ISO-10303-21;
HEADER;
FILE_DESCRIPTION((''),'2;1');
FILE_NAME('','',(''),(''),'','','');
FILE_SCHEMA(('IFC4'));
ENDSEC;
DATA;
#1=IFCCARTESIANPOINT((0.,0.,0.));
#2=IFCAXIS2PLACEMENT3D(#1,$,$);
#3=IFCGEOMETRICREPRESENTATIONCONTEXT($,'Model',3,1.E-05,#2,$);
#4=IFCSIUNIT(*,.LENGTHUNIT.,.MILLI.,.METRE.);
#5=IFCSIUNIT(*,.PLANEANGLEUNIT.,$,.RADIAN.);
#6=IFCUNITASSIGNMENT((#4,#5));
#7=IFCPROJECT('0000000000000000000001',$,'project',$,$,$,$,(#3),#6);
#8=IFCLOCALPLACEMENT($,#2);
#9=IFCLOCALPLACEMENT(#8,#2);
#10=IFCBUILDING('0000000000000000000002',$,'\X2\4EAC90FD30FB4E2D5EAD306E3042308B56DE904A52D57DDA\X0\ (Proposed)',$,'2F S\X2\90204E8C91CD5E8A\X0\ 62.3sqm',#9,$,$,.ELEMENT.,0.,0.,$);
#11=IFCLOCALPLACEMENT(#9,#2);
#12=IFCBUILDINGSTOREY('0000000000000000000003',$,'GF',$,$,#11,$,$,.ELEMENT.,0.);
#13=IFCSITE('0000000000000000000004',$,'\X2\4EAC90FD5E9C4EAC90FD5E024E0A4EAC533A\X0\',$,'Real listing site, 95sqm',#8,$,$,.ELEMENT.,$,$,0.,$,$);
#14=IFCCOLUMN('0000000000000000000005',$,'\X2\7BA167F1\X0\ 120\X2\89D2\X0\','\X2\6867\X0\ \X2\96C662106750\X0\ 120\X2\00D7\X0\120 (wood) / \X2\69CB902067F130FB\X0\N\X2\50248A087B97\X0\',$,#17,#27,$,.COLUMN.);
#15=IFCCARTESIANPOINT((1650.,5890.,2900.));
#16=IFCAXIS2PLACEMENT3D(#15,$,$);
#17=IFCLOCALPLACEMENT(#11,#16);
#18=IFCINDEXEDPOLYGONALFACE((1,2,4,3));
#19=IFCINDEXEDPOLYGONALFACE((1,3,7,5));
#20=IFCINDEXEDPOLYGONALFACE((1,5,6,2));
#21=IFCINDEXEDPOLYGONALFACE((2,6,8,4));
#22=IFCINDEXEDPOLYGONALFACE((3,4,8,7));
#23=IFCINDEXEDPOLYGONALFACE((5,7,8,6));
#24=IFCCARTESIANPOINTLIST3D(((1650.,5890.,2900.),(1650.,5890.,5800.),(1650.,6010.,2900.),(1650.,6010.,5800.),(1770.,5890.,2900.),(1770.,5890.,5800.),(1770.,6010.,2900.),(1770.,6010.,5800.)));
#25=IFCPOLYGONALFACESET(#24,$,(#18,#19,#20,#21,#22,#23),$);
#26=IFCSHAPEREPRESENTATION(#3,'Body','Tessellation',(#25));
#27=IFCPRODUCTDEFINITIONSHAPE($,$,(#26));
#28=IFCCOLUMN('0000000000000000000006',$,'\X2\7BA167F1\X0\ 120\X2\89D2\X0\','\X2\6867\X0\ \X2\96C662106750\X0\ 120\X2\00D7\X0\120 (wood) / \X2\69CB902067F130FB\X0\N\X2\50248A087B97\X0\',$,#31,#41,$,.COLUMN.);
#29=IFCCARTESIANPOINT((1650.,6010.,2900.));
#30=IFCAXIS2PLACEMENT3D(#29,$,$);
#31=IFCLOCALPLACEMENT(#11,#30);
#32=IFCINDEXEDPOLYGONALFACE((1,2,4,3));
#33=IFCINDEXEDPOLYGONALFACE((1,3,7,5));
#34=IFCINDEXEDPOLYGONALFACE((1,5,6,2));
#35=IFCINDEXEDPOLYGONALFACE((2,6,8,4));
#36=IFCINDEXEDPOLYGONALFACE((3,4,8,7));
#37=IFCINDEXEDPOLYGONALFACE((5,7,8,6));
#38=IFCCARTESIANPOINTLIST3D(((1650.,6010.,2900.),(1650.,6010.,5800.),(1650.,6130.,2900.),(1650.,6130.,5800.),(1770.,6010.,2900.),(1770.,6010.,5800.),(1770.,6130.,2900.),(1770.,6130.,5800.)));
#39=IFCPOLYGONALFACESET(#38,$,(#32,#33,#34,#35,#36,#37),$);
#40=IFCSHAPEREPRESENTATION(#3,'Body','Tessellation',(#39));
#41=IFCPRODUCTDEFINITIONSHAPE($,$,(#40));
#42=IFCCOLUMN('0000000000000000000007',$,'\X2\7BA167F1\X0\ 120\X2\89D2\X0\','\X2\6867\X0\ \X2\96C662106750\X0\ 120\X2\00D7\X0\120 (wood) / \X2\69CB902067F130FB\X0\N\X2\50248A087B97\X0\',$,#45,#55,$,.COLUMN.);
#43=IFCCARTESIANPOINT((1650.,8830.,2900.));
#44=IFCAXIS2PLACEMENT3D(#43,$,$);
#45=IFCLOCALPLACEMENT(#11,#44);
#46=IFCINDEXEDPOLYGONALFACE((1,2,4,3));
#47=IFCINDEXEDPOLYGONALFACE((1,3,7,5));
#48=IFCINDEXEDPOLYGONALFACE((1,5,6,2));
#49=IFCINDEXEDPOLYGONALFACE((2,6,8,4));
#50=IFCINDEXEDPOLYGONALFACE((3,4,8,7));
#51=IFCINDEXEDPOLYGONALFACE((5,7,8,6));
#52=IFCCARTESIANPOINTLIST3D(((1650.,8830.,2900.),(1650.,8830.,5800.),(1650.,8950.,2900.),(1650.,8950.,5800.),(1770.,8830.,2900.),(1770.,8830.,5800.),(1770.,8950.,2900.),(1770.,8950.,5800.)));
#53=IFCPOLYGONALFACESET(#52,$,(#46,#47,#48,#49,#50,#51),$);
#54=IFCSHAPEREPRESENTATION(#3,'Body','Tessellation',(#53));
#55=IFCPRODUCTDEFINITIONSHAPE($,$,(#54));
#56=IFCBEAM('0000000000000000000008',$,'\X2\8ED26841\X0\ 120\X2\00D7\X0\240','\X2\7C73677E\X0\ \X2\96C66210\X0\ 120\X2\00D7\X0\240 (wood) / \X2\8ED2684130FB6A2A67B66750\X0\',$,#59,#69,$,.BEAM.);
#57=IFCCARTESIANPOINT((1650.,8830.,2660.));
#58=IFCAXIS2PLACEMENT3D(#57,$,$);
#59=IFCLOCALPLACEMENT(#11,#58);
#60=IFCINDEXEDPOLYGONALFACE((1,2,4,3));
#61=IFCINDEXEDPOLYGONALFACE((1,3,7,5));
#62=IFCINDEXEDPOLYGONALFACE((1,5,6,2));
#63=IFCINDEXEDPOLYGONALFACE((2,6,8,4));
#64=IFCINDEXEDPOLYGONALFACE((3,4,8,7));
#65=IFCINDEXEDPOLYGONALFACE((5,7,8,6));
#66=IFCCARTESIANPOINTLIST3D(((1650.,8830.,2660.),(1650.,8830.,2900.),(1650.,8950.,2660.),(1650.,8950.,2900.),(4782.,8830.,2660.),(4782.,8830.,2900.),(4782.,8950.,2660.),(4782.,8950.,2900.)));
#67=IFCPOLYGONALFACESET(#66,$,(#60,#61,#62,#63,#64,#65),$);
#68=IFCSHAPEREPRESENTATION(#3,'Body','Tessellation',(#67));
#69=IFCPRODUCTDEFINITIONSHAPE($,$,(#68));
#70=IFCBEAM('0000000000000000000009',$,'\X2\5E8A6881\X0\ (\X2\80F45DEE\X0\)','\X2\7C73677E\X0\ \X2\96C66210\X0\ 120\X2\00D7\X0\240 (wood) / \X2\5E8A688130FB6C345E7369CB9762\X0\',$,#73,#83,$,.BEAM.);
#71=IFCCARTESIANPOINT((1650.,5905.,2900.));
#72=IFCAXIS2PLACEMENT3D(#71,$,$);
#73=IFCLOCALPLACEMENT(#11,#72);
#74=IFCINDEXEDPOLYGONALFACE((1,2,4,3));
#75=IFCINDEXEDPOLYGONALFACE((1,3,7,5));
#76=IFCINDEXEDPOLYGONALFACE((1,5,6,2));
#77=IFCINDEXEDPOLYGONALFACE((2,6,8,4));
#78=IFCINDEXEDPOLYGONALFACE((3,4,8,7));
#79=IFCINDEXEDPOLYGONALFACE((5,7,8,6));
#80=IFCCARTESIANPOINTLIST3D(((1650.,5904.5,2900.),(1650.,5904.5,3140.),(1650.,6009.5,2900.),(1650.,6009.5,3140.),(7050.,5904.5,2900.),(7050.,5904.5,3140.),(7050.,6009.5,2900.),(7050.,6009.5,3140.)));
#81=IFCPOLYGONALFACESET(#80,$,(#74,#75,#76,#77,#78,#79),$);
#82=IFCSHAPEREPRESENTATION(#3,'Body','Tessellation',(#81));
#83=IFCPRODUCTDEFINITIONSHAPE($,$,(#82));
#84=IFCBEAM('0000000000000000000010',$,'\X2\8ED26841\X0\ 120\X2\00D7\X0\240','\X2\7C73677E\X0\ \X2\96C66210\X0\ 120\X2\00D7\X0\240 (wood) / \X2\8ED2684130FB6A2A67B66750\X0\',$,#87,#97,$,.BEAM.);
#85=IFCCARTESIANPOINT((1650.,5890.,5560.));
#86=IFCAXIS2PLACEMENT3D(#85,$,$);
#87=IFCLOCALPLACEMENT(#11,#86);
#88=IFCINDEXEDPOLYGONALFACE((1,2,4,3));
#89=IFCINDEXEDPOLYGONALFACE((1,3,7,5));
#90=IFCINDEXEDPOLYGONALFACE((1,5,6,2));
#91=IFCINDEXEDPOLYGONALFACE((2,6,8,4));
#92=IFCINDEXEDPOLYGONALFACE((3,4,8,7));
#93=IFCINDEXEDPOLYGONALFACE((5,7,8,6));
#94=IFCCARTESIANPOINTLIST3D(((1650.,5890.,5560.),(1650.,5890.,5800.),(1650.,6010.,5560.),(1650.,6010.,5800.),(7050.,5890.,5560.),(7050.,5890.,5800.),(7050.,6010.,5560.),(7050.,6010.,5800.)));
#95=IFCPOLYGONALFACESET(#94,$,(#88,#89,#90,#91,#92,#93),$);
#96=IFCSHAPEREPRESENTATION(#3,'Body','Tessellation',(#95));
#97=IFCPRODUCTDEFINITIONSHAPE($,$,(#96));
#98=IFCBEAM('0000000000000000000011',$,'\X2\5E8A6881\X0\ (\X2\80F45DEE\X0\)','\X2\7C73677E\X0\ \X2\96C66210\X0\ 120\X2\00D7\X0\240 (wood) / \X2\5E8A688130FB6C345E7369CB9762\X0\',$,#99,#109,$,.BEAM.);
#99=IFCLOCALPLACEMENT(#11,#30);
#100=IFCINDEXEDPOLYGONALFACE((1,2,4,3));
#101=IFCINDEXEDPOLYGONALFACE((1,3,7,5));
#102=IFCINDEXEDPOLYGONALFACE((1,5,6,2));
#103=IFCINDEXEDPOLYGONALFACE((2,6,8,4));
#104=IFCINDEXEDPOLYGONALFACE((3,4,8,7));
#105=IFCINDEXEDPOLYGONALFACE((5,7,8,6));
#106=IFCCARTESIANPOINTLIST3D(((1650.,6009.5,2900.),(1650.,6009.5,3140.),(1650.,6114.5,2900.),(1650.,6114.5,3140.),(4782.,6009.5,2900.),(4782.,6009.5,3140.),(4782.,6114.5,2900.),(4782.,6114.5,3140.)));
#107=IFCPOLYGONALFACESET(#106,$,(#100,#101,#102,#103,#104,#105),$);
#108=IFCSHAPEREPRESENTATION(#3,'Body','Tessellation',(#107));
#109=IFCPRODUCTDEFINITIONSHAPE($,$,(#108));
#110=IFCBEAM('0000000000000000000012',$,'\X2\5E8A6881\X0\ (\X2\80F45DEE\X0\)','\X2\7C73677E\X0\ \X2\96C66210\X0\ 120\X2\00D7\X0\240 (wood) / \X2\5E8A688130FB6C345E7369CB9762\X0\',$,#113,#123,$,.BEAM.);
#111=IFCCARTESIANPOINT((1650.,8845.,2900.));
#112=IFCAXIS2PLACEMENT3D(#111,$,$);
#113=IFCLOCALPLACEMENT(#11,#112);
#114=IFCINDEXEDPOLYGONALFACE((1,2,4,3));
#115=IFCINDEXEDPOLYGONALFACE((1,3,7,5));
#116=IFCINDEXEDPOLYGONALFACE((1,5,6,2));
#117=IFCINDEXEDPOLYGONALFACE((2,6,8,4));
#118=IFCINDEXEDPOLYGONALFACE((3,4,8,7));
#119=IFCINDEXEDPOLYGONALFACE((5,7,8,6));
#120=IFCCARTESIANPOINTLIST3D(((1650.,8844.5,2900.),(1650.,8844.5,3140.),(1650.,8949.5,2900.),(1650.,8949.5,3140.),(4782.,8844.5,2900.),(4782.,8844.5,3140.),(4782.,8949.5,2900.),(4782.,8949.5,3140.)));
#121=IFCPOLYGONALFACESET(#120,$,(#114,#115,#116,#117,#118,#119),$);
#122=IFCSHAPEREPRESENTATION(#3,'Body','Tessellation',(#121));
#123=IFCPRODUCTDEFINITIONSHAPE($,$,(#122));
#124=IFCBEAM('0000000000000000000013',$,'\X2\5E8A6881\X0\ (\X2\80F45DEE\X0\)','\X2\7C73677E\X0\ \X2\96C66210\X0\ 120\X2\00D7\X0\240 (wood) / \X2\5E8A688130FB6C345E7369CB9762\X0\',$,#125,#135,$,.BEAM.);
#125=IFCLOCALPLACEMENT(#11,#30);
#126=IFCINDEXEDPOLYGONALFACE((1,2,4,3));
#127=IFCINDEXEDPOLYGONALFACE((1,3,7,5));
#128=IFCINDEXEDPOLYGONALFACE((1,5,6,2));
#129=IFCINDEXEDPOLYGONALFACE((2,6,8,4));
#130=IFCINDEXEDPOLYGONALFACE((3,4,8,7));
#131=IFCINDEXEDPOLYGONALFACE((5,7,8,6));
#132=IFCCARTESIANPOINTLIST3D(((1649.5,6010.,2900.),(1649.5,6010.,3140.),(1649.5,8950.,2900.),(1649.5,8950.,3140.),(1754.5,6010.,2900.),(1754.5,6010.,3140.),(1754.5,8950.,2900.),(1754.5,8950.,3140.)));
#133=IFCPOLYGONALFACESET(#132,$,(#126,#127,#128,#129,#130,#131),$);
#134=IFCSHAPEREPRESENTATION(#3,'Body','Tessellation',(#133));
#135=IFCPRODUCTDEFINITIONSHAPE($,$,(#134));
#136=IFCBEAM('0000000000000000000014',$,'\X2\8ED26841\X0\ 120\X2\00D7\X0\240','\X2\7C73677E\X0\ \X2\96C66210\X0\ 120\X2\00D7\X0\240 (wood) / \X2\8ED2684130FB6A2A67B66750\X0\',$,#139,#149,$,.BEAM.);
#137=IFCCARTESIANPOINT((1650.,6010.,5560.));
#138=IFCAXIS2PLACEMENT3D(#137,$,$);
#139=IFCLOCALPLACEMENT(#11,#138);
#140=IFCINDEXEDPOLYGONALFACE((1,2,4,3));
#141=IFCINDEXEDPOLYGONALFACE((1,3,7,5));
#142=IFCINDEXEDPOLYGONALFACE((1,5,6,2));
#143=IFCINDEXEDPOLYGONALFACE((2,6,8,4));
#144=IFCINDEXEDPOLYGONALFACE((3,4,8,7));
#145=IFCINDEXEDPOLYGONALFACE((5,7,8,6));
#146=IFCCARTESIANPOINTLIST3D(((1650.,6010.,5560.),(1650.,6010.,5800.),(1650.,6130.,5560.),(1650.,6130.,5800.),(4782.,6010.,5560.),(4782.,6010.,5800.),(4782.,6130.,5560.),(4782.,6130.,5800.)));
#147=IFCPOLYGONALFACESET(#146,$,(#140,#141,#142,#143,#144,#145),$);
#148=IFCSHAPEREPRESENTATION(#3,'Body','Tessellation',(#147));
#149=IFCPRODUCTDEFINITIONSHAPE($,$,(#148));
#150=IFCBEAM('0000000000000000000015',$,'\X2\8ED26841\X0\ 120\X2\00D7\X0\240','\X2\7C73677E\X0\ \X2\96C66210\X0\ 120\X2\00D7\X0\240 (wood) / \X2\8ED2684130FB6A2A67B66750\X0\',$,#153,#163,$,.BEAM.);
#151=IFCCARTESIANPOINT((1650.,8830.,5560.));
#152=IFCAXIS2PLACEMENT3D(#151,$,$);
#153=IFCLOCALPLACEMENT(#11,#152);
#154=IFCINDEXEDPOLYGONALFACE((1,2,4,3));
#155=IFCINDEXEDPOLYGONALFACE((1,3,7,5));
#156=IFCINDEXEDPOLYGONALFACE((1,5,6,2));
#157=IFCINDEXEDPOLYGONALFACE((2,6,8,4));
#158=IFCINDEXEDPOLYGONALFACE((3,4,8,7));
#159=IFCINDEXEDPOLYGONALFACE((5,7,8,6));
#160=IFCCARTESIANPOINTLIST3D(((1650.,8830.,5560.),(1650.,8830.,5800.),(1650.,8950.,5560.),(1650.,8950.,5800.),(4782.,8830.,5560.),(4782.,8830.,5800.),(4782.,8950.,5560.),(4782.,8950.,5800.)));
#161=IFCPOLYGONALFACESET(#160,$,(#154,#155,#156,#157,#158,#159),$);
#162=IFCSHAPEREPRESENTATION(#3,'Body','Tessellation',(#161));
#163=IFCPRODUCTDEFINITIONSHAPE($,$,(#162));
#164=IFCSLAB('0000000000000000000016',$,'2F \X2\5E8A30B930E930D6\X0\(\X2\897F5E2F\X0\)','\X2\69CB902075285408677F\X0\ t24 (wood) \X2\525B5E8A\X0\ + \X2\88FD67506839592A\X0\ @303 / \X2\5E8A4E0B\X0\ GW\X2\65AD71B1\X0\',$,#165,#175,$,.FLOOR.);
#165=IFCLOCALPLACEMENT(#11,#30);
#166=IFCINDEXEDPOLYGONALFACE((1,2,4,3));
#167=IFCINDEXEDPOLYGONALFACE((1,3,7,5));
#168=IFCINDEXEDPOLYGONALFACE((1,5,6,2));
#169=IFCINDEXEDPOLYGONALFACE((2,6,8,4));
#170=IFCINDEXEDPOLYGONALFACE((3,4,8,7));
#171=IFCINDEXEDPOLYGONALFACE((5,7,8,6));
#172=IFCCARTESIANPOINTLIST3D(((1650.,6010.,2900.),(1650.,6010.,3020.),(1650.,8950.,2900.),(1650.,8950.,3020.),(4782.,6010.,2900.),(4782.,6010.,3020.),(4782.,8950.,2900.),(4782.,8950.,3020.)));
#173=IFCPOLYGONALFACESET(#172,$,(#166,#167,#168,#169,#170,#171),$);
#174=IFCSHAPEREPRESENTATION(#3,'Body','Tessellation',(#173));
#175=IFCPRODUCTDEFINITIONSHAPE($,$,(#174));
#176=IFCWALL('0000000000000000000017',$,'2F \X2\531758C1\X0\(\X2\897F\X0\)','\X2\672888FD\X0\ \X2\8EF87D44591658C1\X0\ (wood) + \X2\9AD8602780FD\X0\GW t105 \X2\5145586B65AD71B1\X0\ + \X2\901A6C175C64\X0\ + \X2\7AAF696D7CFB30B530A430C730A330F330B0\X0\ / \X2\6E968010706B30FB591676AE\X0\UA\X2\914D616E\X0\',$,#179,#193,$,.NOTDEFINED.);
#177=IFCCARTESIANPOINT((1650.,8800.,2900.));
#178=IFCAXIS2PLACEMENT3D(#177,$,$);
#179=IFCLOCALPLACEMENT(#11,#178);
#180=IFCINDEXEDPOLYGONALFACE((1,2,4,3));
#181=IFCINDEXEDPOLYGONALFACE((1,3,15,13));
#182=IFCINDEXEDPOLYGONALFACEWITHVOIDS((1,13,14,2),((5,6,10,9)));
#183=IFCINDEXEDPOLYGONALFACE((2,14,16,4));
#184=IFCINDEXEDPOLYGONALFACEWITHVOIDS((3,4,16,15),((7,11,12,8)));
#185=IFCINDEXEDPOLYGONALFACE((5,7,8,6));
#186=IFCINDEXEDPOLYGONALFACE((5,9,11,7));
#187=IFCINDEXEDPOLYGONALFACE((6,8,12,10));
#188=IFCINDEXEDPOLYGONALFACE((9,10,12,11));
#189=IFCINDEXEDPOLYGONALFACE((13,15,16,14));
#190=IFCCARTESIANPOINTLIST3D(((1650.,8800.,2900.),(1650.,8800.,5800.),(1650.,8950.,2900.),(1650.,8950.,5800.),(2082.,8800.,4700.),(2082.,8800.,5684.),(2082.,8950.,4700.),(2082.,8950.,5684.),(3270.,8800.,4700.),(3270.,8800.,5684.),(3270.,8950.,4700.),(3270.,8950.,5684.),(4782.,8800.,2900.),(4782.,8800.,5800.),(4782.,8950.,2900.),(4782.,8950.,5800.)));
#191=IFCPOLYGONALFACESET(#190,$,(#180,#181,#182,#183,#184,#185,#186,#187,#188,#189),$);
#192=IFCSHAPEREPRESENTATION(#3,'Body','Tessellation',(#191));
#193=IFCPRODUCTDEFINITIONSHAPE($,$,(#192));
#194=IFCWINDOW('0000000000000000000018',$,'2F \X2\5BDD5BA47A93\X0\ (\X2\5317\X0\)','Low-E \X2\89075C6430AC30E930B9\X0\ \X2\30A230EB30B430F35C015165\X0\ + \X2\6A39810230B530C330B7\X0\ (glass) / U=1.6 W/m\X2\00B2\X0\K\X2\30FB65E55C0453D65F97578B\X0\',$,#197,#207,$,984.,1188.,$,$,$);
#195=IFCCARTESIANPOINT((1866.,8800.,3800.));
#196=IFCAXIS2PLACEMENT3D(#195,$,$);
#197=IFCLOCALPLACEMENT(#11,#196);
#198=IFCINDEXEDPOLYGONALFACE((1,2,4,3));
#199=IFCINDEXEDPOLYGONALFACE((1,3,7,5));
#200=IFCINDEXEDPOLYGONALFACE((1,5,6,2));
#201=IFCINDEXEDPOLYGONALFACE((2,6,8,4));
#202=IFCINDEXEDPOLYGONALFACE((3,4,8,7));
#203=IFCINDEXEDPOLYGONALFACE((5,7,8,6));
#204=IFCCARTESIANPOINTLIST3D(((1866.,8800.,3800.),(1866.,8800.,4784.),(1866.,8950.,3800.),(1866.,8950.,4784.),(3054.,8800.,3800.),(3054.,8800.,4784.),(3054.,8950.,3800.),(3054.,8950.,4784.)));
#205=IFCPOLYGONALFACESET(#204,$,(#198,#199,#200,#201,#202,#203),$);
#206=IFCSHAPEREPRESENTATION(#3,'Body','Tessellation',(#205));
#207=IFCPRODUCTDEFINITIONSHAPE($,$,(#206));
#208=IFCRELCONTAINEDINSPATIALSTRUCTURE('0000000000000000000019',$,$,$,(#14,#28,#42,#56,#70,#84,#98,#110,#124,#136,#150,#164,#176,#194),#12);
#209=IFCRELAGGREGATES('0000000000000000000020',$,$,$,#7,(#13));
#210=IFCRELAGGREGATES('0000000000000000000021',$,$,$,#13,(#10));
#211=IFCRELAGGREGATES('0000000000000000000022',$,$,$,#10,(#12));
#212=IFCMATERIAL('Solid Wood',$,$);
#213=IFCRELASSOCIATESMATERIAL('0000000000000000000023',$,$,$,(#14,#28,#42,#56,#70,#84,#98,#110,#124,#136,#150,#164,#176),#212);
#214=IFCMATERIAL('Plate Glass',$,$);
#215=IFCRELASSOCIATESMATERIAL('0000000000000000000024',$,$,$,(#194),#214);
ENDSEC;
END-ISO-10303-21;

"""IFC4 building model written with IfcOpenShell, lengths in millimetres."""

from ifc_helpers import new_model, si_unit, frame, frame_2d, origin, place, context, project, spatial, rectangle, extrude, material, element, fill, save


model = new_model("IFC4")

# Units and contexts
model_context = context("Model", 3, precision=1e-05, world=origin())
ifc_project = project(units=[si_unit("LENGTHUNIT", "METRE", prefix="MILLI"), si_unit("PLANEANGLEUNIT", "RADIAN")], contexts=[model_context])

# Site, building, storey
site_placement = place(None, origin())
site = spatial("IfcSite", under=ifc_project, at=site_placement, Name="京都府京都市上京区", ObjectType="Real listing site, 95sqm", CompositionType="ELEMENT", RefElevation=0.0)
building_placement = place(site_placement, origin())
building = spatial("IfcBuilding", under=site, at=building_placement, Name="京都・中庭のある回遊動線 (Proposed)", ObjectType="2F S造二重床 62.3sqm", CompositionType="ELEMENT", ElevationOfRefHeight=0.0, ElevationOfTerrain=0.0)
storey_placement = place(building_placement, origin())
storey = spatial("IfcBuildingStorey", under=building, at=storey_placement, Name="GF", CompositionType="ELEMENT", Elevation=0.0)

# Columns
ifc_material_1 = material(Name="Solid Wood")
column_1_placement = place(storey_placement, frame((1650.0, 5890.0, 2900.0)))
element("IfcColumn", 1, at=column_1_placement, inside=storey, material=ifc_material_1, Name="管柱 120角", Description="桧 集成材 120×120 (wood) / 構造柱・N値計算", PredefinedType="COLUMN", context=model_context, shape_type="SweptSolid", body=[
    extrude(rectangle(XDim=120.0, YDim=120.0, at=frame_2d((60.0, 60.0))), frame((1650.0, 5890.0, 2900.0)), (0.0, 0.0, 1.0), 2900.0),
])
column_2_placement = place(storey_placement, frame((1650.0, 6010.0, 2900.0)))
element("IfcColumn", 2, at=column_2_placement, inside=storey, material=ifc_material_1, Name="管柱 120角", Description="桧 集成材 120×120 (wood) / 構造柱・N値計算", PredefinedType="COLUMN", context=model_context, shape_type="SweptSolid", body=[
    extrude(rectangle(XDim=120.0, YDim=120.0, at=frame_2d((60.0, 60.0))), frame((1650.0, 6010.0, 2900.0)), (0.0, 0.0, 1.0), 2900.0),
])
column_3_placement = place(storey_placement, frame((1650.0, 8830.0, 2900.0)))
element("IfcColumn", 3, at=column_3_placement, inside=storey, material=ifc_material_1, Name="管柱 120角", Description="桧 集成材 120×120 (wood) / 構造柱・N値計算", PredefinedType="COLUMN", context=model_context, shape_type="SweptSolid", body=[
    extrude(rectangle(XDim=120.0, YDim=120.0, at=frame_2d((60.0, 60.0))), frame((1650.0, 8830.0, 2900.0)), (0.0, 0.0, 1.0), 2900.0),
])

# Beams
beam_1_placement = place(storey_placement, frame((1650.0, 8830.0, 2660.0)))
element("IfcBeam", 4, at=beam_1_placement, inside=storey, material=ifc_material_1, Name="軒桁 120×240", Description="米松 集成 120×240 (wood) / 軒桁・横架材", PredefinedType="BEAM", context=model_context, shape_type="SweptSolid", body=[
    extrude(rectangle(XDim=3132.0, YDim=120.0, at=frame_2d((1566.0, 60.0))), frame((1650.0, 8830.0, 2660.0)), (0.0, 0.0, 1.0), 240.0),
])
beam_2_placement = place(storey_placement, frame((1650.0, 5905.0, 2900.0)))
element("IfcBeam", 5, at=beam_2_placement, inside=storey, material=ifc_material_1, Name="床梁 (胴差)", Description="米松 集成 120×240 (wood) / 床梁・水平構面", PredefinedType="BEAM", context=model_context, shape_type="SweptSolid", body=[
    extrude(rectangle(XDim=5400.0, YDim=105.0, at=frame_2d((2700.0, 52.0))), frame((1650.0, 5905.0, 2900.0)), (0.0, 0.0, 1.0), 240.0),
])
beam_3_placement = place(storey_placement, frame((1650.0, 5890.0, 5560.0)))
element("IfcBeam", 6, at=beam_3_placement, inside=storey, material=ifc_material_1, Name="軒桁 120×240", Description="米松 集成 120×240 (wood) / 軒桁・横架材", PredefinedType="BEAM", context=model_context, shape_type="SweptSolid", body=[
    extrude(rectangle(XDim=5400.0, YDim=120.0, at=frame_2d((2700.0, 60.0))), frame((1650.0, 5890.0, 5560.0)), (0.0, 0.0, 1.0), 240.0),
])
beam_4_placement = place(storey_placement, frame((1650.0, 6010.0, 2900.0)))
element("IfcBeam", 7, at=beam_4_placement, inside=storey, material=ifc_material_1, Name="床梁 (胴差)", Description="米松 集成 120×240 (wood) / 床梁・水平構面", PredefinedType="BEAM", context=model_context, shape_type="SweptSolid", body=[
    extrude(rectangle(XDim=3132.0, YDim=105.0, at=frame_2d((1566.0, 52.0))), frame((1650.0, 6010.0, 2900.0)), (0.0, 0.0, 1.0), 240.0),
])
beam_5_placement = place(storey_placement, frame((1650.0, 8845.0, 2900.0)))
element("IfcBeam", 8, at=beam_5_placement, inside=storey, material=ifc_material_1, Name="床梁 (胴差)", Description="米松 集成 120×240 (wood) / 床梁・水平構面", PredefinedType="BEAM", context=model_context, shape_type="SweptSolid", body=[
    extrude(rectangle(XDim=3132.0, YDim=105.0, at=frame_2d((1566.0, 52.0))), frame((1650.0, 8845.0, 2900.0)), (0.0, 0.0, 1.0), 240.0),
])
beam_6_placement = place(storey_placement, frame((1650.0, 6010.0, 2900.0)))
element("IfcBeam", 9, at=beam_6_placement, inside=storey, material=ifc_material_1, Name="床梁 (胴差)", Description="米松 集成 120×240 (wood) / 床梁・水平構面", PredefinedType="BEAM", context=model_context, shape_type="SweptSolid", body=[
    extrude(rectangle(XDim=105.0, YDim=2940.0, at=frame_2d((52.0, 1470.0))), frame((1650.0, 6010.0, 2900.0)), (0.0, 0.0, 1.0), 240.0),
])
beam_7_placement = place(storey_placement, frame((1650.0, 6010.0, 5560.0)))
element("IfcBeam", 10, at=beam_7_placement, inside=storey, material=ifc_material_1, Name="軒桁 120×240", Description="米松 集成 120×240 (wood) / 軒桁・横架材", PredefinedType="BEAM", context=model_context, shape_type="SweptSolid", body=[
    extrude(rectangle(XDim=3132.0, YDim=120.0, at=frame_2d((1566.0, 60.0))), frame((1650.0, 6010.0, 5560.0)), (0.0, 0.0, 1.0), 240.0),
])
beam_8_placement = place(storey_placement, frame((1650.0, 8830.0, 5560.0)))
element("IfcBeam", 11, at=beam_8_placement, inside=storey, material=ifc_material_1, Name="軒桁 120×240", Description="米松 集成 120×240 (wood) / 軒桁・横架材", PredefinedType="BEAM", context=model_context, shape_type="SweptSolid", body=[
    extrude(rectangle(XDim=3132.0, YDim=120.0, at=frame_2d((1566.0, 60.0))), frame((1650.0, 8830.0, 5560.0)), (0.0, 0.0, 1.0), 240.0),
])

# Slab
slab_placement = place(storey_placement, frame((1650.0, 6010.0, 2900.0)))
element("IfcSlab", 12, at=slab_placement, inside=storey, material=ifc_material_1, Name="2F 床スラブ(西帯)", Description="構造用合板 t24 (wood) 剛床 + 製材根太 @303 / 床下 GW断熱", PredefinedType="FLOOR", context=model_context, shape_type="SweptSolid", body=[
    extrude(rectangle(XDim=3132.0, YDim=2940.0, at=frame_2d((1566.0, 1470.0))), frame((1650.0, 6010.0, 2900.0)), (0.0, 0.0, 1.0), 120.0),
])

# Wall, opening, window
wall_1_placement = place(storey_placement, frame((1650.0, 8800.0, 2900.0)))
wall_1 = element("IfcWall", 13, at=wall_1_placement, inside=storey, material=ifc_material_1, Name="2F 北壁(西)", Description="木製 軸組外壁 (wood) + 高性能GW t105 充填断熱 + 通気層 + 窯業系サイディング / 準耐火・外皮UA配慮", PredefinedType="NOTDEFINED", context=model_context, shape_type="SweptSolid", body=[
    extrude(rectangle(XDim=3132.0, YDim=150.0, at=frame_2d((1566.0, 75.0))), frame((1650.0, 8800.0, 2900.0)), (0.0, 0.0, 1.0), 2900.0),
])
opening_placement = place(storey_placement, frame((1866.0, 8800.0, 3800.0)))
opening = element("IfcOpeningElement", 14, at=opening_placement, cuts=wall_1, PredefinedType="NOTDEFINED", context=model_context, shape_type="SweptSolid", body=[
    extrude(rectangle(XDim=1188.0, YDim=150.0, at=frame_2d((594.0, 75.0))), frame((1866.0, 8800.0, 3800.0)), (0.0, 0.0, 1.0), 984.0),
])
ifc_material_2 = material(Name="Plate Glass")
window_placement = place(storey_placement, frame((1866.0, 8800.0, 3800.0)))
window = element("IfcWindow", 15, at=window_placement, inside=storey, material=ifc_material_2, Name="2F 寝室窓 (北)", Description="Low-E 複層ガラス アルゴン封入 + 樹脂サッシ (glass) / U=1.6 W/m²K・日射取得型", OverallHeight=984.0, OverallWidth=1188.0, context=model_context, shape_type="SweptSolid", body=[
    extrude(rectangle(XDim=1188.0, YDim=150.0, at=frame_2d((594.0, 75.0))), frame((1866.0, 8800.0, 3800.0)), (0.0, 0.0, 1.0), 984.0),
])
fill(opening, window)

save(model, "model.ifc")
